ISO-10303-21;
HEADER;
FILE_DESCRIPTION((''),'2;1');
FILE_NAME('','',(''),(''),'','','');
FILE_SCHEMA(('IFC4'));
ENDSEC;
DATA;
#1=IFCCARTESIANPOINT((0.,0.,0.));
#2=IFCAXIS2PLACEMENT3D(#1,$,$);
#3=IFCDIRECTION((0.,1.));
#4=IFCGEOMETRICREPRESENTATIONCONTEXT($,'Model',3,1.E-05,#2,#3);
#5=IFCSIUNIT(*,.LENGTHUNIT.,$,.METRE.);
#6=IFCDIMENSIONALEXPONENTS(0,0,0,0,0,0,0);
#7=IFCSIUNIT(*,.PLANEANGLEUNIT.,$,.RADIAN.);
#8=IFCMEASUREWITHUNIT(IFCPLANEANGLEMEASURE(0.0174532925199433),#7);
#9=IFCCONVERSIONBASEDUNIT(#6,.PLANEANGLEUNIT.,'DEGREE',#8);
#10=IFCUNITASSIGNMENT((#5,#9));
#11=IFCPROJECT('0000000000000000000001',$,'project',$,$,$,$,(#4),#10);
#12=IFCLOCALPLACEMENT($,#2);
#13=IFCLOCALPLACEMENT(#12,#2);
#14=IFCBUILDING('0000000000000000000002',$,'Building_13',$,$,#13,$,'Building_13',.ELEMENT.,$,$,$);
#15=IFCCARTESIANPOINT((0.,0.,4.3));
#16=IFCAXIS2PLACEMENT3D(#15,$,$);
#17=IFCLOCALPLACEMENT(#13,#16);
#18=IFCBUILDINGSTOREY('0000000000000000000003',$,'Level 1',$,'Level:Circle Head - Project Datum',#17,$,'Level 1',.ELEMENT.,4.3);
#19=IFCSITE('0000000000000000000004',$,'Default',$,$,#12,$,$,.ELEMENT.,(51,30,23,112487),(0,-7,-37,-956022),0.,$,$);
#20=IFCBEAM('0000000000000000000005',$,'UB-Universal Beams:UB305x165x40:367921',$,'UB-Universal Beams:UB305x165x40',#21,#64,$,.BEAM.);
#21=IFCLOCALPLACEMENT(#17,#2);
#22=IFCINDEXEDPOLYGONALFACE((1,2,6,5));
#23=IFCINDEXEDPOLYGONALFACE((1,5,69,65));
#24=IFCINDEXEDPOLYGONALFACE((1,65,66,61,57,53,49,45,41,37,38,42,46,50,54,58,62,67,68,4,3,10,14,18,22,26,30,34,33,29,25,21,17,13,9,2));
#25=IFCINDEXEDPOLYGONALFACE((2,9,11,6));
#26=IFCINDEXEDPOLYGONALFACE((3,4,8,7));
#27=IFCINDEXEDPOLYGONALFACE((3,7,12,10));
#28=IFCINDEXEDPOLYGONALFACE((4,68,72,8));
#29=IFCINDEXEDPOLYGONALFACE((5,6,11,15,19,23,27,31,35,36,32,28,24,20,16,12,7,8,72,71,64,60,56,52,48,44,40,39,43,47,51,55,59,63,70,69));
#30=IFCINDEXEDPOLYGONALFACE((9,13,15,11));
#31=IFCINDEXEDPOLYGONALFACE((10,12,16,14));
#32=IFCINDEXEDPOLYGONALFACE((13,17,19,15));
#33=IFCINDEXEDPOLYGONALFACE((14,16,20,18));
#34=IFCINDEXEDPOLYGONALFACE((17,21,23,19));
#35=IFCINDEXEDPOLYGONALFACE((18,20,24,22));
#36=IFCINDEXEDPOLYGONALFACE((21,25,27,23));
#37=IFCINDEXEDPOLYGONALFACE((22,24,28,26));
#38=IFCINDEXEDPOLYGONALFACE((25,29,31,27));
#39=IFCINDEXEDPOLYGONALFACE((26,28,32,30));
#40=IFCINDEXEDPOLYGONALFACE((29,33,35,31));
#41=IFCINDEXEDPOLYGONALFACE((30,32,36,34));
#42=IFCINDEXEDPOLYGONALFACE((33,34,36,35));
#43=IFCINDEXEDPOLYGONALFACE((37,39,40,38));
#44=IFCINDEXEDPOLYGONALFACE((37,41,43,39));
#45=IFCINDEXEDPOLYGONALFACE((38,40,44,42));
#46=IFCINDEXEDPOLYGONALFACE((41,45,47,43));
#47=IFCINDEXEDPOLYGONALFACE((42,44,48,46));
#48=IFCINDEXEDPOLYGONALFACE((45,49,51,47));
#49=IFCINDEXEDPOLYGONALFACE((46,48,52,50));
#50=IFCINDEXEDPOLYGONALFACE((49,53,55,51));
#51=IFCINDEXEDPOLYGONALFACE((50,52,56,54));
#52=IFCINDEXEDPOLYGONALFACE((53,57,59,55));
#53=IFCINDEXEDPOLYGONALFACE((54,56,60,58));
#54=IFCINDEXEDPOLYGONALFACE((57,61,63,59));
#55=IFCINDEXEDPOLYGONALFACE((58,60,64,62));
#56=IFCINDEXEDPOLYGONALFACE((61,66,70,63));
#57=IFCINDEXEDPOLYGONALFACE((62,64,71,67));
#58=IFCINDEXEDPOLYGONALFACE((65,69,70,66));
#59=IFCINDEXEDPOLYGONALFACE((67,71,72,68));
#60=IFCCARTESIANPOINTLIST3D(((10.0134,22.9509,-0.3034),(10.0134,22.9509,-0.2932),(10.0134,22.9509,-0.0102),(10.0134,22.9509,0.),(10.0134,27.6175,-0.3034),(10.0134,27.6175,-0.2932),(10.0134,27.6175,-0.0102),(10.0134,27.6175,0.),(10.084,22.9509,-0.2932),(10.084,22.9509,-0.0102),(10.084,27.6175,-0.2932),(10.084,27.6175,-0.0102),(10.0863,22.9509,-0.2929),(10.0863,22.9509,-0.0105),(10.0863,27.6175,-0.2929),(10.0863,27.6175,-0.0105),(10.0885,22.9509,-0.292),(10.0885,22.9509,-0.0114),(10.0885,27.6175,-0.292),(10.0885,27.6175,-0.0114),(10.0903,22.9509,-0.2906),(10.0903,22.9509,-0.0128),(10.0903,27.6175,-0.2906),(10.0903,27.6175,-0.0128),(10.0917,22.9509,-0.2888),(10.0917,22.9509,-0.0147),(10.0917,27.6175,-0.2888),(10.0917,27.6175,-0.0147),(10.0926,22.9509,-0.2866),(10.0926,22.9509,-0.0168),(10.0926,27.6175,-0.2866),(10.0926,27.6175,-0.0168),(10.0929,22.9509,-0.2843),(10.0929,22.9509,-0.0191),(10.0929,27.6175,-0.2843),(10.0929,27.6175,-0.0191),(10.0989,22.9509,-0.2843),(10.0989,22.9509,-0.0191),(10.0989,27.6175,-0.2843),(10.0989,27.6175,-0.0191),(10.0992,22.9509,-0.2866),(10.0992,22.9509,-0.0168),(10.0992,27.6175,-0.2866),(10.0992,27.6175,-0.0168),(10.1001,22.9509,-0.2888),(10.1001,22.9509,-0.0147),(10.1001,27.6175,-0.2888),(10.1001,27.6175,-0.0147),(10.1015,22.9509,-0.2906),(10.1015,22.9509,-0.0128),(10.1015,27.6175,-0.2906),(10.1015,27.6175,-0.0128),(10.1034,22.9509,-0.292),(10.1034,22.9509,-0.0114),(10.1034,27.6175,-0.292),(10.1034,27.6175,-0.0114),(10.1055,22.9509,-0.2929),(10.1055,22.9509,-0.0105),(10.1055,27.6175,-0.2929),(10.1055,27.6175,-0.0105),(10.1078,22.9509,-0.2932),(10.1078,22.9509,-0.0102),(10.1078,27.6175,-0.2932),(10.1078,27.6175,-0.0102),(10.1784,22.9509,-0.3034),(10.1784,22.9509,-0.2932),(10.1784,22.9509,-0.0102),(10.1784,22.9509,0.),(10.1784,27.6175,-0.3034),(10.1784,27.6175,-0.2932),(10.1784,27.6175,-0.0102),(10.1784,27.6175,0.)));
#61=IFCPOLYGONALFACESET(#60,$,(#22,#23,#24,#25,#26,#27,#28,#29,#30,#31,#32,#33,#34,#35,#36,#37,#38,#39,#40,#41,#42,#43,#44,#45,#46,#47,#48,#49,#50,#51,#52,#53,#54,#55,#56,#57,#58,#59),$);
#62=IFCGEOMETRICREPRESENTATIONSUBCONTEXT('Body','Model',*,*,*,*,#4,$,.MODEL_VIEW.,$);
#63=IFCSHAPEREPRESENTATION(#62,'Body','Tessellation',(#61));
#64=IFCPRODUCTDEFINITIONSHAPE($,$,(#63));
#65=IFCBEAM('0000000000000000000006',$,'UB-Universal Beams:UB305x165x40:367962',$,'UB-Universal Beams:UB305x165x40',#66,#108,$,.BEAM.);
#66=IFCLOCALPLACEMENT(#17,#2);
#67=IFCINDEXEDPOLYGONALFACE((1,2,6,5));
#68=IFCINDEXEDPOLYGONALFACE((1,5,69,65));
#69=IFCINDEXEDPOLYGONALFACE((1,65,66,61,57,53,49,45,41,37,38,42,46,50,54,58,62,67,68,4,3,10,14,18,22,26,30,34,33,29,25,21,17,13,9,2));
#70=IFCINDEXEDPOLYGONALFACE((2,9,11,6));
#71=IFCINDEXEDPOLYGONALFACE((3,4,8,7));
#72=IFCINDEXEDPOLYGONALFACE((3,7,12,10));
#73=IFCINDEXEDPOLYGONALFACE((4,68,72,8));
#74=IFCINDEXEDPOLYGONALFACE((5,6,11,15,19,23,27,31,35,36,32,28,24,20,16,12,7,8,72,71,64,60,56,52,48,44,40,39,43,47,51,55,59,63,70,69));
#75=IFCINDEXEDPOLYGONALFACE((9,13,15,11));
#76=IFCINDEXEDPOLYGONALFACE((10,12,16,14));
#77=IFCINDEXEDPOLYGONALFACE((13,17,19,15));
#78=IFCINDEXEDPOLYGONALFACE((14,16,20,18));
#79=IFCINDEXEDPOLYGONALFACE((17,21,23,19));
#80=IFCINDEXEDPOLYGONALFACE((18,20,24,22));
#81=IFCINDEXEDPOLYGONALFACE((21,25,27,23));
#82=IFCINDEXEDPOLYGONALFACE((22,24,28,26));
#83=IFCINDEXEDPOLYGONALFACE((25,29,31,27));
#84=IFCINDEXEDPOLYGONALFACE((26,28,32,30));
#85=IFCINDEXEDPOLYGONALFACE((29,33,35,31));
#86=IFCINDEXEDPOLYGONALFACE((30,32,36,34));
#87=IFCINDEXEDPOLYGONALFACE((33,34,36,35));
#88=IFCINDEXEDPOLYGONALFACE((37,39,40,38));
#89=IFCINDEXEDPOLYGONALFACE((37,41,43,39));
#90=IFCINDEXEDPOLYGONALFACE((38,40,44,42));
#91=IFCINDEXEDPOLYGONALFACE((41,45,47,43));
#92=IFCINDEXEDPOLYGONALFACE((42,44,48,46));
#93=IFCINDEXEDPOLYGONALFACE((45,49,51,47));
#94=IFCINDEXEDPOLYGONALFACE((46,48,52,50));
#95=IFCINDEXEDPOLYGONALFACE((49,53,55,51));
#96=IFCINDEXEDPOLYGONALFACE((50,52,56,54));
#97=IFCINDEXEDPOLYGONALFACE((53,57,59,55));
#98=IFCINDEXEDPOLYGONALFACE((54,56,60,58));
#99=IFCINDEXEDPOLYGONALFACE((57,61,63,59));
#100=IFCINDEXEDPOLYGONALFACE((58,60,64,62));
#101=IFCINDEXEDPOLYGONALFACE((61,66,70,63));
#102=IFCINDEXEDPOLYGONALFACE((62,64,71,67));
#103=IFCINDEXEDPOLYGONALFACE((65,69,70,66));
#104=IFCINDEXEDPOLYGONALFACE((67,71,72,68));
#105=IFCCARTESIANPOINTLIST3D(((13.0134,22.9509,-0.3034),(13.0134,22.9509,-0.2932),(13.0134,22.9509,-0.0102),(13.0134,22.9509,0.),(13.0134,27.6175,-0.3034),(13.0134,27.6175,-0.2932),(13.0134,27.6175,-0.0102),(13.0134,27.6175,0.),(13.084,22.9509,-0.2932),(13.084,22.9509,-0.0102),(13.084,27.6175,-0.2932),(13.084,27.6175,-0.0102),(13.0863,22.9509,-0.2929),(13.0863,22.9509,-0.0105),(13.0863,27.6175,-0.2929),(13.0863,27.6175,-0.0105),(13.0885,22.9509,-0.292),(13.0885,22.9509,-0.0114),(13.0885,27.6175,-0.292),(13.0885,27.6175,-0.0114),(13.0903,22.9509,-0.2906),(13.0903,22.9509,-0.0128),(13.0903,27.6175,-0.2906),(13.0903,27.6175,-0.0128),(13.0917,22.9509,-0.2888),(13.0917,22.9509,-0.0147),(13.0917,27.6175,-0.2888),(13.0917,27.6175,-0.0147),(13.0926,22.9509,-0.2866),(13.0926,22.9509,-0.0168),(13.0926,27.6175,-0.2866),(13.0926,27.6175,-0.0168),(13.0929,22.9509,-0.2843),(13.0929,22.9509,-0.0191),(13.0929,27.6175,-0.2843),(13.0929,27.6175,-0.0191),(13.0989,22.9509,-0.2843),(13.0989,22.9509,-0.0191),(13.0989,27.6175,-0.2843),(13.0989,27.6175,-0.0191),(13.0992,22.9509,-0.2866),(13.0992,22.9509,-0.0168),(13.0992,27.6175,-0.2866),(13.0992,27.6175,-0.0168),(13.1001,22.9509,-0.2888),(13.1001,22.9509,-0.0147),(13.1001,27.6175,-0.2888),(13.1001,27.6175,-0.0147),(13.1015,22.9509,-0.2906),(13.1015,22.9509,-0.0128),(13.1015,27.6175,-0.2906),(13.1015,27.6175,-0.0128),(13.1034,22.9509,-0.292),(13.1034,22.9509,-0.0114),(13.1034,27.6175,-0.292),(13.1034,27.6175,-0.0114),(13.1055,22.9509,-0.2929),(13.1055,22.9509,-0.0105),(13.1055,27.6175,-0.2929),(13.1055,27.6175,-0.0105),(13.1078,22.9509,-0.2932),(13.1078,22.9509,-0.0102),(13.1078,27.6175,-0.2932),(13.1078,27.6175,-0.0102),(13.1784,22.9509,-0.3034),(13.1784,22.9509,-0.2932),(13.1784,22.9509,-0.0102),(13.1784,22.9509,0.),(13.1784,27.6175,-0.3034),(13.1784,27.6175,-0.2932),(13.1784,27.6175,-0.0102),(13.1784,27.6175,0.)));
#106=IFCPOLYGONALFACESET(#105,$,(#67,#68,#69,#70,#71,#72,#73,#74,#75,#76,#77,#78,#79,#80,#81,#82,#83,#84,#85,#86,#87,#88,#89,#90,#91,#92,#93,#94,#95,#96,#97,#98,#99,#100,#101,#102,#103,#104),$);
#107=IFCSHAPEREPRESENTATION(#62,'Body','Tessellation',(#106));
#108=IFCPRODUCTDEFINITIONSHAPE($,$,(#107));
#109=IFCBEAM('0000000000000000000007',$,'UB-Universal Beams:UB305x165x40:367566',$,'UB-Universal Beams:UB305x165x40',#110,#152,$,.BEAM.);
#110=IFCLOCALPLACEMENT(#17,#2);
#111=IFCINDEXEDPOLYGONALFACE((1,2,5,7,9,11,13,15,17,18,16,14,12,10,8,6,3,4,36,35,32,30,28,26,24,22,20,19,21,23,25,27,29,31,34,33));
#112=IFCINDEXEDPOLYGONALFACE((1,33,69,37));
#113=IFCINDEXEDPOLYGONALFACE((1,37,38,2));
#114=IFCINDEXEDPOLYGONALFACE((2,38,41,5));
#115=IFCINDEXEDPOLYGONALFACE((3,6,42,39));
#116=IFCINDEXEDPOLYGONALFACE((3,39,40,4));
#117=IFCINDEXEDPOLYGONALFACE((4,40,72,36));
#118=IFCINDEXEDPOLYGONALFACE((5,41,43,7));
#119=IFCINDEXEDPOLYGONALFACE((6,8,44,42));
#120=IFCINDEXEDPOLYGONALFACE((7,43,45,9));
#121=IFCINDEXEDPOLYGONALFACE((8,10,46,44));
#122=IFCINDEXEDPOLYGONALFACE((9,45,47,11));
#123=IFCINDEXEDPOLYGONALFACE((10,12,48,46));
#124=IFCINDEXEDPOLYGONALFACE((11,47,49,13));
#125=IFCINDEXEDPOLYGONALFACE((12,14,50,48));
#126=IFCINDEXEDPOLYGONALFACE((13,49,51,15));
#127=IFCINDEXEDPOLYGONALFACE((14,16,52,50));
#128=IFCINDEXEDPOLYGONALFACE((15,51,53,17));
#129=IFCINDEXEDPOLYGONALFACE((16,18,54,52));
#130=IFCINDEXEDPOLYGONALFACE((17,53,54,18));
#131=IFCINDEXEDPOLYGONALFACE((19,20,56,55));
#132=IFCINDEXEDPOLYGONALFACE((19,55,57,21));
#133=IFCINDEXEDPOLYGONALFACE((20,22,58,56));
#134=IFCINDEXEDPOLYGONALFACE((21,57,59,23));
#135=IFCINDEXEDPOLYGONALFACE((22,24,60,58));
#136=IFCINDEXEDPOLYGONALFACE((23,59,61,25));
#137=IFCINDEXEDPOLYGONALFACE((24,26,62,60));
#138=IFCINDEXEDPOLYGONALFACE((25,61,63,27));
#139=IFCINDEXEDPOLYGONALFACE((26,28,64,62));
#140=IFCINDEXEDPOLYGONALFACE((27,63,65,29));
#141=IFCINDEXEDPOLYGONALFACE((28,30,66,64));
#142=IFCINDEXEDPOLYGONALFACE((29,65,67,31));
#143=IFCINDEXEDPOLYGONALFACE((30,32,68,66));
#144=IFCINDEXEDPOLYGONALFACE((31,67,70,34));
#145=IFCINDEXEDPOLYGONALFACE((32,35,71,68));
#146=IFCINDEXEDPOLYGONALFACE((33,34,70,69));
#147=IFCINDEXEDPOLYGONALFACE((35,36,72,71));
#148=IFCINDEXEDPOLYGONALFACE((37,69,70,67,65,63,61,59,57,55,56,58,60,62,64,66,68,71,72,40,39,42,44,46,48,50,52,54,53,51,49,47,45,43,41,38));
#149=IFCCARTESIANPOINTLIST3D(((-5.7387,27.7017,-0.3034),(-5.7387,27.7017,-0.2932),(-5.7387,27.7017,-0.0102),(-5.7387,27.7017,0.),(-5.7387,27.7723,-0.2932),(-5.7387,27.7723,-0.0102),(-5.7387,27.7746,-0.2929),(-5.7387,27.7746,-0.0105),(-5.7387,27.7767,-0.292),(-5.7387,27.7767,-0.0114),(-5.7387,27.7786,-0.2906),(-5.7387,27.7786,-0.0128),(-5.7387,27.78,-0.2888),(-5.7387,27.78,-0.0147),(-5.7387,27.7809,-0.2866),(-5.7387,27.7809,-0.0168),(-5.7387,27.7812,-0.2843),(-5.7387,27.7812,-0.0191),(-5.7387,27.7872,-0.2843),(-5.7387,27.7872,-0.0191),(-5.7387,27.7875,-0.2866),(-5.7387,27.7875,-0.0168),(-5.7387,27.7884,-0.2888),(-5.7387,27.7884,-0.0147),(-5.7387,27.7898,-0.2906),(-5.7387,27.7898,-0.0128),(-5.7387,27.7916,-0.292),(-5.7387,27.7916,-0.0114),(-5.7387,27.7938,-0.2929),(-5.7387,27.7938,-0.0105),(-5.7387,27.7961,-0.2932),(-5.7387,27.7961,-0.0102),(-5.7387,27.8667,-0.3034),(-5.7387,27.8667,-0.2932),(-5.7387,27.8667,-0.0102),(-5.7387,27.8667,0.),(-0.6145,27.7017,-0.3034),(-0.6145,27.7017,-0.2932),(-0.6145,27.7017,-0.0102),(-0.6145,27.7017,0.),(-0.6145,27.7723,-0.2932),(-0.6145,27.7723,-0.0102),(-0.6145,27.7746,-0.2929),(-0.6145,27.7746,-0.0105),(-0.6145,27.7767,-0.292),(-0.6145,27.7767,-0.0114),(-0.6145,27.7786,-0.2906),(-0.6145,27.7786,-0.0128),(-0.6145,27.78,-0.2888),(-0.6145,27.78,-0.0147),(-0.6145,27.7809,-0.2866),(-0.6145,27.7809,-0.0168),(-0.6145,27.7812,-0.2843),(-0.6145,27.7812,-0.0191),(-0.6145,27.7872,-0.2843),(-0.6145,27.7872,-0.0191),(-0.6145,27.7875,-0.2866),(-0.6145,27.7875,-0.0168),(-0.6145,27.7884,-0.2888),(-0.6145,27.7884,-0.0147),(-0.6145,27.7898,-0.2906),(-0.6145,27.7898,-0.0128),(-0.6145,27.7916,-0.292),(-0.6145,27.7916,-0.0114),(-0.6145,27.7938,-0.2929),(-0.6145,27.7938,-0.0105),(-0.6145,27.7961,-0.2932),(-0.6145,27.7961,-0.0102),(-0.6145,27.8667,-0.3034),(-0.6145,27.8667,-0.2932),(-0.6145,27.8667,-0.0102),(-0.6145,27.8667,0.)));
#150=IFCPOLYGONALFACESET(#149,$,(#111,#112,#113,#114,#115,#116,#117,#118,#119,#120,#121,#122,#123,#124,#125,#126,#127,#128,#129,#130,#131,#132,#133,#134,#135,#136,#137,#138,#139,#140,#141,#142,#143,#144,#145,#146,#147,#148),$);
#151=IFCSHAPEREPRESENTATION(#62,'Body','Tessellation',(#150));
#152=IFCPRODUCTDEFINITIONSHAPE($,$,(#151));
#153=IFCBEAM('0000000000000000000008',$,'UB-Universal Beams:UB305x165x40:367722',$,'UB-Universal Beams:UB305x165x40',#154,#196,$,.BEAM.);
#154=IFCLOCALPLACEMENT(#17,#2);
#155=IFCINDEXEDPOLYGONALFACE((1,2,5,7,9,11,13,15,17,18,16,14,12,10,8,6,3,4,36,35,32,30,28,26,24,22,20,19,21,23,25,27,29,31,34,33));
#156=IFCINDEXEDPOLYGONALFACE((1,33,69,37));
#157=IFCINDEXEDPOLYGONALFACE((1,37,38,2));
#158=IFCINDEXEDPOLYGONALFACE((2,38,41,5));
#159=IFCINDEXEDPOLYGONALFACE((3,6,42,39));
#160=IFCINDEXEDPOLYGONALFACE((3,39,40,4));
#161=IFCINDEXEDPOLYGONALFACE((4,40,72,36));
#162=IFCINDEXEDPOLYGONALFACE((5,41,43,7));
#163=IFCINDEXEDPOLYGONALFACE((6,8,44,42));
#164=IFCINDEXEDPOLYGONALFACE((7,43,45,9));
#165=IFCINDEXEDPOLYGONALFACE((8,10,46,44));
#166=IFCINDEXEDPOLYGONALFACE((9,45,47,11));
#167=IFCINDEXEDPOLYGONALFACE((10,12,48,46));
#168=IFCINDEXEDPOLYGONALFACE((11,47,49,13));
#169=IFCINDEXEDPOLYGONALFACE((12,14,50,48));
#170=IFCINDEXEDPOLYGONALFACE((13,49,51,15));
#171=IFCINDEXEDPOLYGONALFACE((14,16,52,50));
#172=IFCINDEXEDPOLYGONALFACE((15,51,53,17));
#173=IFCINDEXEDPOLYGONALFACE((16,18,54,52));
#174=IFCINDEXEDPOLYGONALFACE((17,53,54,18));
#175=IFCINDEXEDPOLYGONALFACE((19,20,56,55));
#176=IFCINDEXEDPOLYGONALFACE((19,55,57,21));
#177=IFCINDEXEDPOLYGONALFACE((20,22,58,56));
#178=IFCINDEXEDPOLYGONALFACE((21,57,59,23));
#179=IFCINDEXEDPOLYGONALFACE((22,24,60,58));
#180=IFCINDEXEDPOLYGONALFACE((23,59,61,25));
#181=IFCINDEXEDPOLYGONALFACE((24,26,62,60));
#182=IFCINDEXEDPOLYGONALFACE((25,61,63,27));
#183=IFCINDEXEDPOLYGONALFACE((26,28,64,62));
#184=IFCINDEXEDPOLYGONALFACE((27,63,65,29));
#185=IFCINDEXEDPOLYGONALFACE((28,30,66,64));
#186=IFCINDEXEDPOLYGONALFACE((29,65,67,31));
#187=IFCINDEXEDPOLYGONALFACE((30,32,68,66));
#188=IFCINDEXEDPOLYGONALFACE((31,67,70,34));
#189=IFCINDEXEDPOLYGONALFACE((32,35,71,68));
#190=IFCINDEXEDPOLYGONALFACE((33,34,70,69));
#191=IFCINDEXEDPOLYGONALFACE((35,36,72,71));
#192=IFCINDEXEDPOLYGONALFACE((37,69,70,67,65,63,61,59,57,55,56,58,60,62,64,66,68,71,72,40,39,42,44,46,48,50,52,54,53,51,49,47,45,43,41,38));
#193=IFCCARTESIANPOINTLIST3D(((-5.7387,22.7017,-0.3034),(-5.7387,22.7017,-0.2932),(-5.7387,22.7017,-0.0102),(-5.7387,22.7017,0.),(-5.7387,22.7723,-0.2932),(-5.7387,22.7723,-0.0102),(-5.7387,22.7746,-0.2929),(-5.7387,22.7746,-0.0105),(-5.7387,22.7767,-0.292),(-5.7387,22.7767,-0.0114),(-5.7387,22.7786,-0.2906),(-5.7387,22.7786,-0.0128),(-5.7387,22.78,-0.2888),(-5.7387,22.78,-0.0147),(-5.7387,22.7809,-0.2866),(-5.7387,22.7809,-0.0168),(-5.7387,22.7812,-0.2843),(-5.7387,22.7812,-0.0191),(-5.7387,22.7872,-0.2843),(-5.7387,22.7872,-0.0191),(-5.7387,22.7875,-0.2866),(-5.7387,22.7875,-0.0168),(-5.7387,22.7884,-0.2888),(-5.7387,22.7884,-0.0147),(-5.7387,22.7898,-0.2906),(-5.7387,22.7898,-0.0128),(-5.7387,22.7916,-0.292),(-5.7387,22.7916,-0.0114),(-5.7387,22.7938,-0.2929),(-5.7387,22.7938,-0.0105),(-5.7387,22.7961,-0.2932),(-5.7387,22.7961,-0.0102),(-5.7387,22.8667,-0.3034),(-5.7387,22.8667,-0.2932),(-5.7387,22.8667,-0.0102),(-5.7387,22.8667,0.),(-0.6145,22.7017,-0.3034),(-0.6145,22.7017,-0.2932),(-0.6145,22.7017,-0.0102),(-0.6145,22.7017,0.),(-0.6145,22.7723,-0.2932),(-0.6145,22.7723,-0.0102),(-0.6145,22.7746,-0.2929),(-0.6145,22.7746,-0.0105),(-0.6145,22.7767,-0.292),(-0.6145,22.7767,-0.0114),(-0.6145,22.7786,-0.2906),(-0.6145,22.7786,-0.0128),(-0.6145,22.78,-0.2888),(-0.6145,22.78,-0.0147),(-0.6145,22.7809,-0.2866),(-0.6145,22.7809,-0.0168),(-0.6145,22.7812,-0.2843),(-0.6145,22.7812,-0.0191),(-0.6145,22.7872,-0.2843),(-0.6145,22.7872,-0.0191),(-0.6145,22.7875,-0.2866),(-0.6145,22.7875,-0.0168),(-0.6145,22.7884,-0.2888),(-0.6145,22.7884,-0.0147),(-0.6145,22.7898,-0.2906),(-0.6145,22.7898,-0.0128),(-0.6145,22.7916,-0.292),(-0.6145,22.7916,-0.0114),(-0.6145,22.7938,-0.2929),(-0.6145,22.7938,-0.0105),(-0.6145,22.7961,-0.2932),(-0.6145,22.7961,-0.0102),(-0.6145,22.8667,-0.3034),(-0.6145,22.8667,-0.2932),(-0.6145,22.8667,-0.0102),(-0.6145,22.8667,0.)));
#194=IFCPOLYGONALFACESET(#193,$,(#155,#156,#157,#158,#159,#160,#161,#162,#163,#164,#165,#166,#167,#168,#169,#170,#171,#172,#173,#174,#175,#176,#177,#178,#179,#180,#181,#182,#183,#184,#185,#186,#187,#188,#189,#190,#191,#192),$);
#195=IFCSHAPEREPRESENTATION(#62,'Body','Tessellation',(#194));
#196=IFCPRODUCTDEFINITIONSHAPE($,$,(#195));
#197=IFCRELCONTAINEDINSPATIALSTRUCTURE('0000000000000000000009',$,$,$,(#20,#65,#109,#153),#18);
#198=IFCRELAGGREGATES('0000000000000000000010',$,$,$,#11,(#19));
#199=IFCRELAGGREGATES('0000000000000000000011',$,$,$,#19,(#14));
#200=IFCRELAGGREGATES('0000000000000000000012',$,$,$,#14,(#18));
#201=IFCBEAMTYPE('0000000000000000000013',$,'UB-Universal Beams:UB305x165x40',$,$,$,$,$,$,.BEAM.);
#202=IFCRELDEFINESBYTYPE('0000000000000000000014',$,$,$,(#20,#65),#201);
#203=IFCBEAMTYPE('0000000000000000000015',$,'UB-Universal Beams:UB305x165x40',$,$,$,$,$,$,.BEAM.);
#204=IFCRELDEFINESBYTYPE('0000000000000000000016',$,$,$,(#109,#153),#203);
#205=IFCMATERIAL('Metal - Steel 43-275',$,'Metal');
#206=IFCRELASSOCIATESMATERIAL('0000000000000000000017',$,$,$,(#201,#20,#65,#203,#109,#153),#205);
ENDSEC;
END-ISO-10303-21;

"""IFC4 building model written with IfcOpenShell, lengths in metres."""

from ifc_helpers import new_model, entity, si_unit, converted_unit, direction, frame, origin, place, context, subcontext, project, spatial, line, arc, indexed_curve, outline, extrude, source, transform, mapped, material, type_object, type_shapes, element, save


model = new_model("IFC4")

# Units and contexts
model_context = context("Model", 3, precision=1e-05, world=origin(), true_north=direction((0.0, 1.0)))
body_context = subcontext(model_context, "Body", "Model", "MODEL_VIEW")
ifc_project = project(units=[si_unit("LENGTHUNIT", "METRE"), converted_unit("PLANEANGLEUNIT", "DEGREE", entity("IfcPlaneAngleMeasure", 0.0174532925199433), si_unit("PLANEANGLEUNIT", "RADIAN"), dimensions=[0, 0, 0, 0, 0, 0, 0])], contexts=[model_context])

# Site, building, storey
site_placement = place(None, origin())
site = spatial("IfcSite", under=ifc_project, at=site_placement, Name="Default", CompositionType="ELEMENT", RefLatitude=(51, 30, 23, 112487), RefLongitude=(0, -7, -37, -956022), RefElevation=0.0)
building_placement = place(site_placement, origin())
building = spatial("IfcBuilding", under=site, at=building_placement, Name="Building_13", LongName="Building_13", CompositionType="ELEMENT")
storey_placement = place(building_placement, frame((0.0, 0.0, 4.3)))
storey = spatial("IfcBuildingStorey", under=building, at=storey_placement, Name="Level 1", ObjectType="Level:Circle Head - Project Datum", LongName="Level 1", CompositionType="ELEMENT", Elevation=4.3)

# Beams
ifc_material_1 = material(Name="Metal - Steel 43-275", Category="Metal")
beam_type_1 = type_object("IfcBeamType", Name="UB-Universal Beams:UB305x165x40", PredefinedType="BEAM", material=ifc_material_1)
shared_shape_1 = source(origin(), body_context, "Body", "SweptSolid", [
    extrude(outline(indexed_curve([(-0.0825, -0.1415), (-0.0825, -0.1517), (0.0825, -0.1517), (0.0825, -0.1415), (0.0119, -0.1415), (0.0056, -0.1389), (0.003, -0.1326), (0.003, 0.1326), (0.0056, 0.1389), (0.0119, 0.1415), (0.0825, 0.1415), (0.0825, 0.1517), (-0.0825, 0.1517), (-0.0825, 0.1415), (-0.0119, 0.1415), (-0.0056, 0.1389), (-0.003, 0.1326), (-0.003, -0.1326), (-0.0056, -0.1389), (-0.0119, -0.1415)], segments=[line(1, 2, 3, 4, 5), arc(5, 6, 7), line(7, 8), arc(8, 9, 10), line(10, 11, 12, 13, 14, 15), arc(15, 16, 17), line(17, 18), arc(18, 19, 20), line(20, 1)], self_intersect=False)), frame((-2.3333, 0.0, 0.0), z_axis=(-1.0, 0.0, 0.0), x_axis=(0.0, -1.0, 0.0)), (0.0, 0.0, -1.0), 4.6666),
])
type_shapes(beam_type_1, [shared_shape_1])
for number, where, z_axis, x_axis, name in (
    (1, (10.0959, 25.2842, -0.1517), (0.0, 0.0, 1.0), (0.0, -1.0, 0.0), "UB-Universal Beams:UB305x165x40:367921"),
    (2, (13.0959, 25.2842, -0.1517), (0.0, 0.0, 1.0), (0.0, -1.0, 0.0), "UB-Universal Beams:UB305x165x40:367962"),
):
    element("IfcBeam", number, at=place(storey_placement, frame(where, z_axis=z_axis, x_axis=x_axis)), inside=storey, type_object=beam_type_1, material=ifc_material_1, Name=name, ObjectType="UB-Universal Beams:UB305x165x40", PredefinedType="BEAM", context=body_context, shape_type="MappedRepresentation", body=[
        mapped(shared_shape_1, transform((0.0, 0.0, 0.0), scale=1.0)),
    ])
beam_type_2 = type_object("IfcBeamType", Name="UB-Universal Beams:UB305x165x40", PredefinedType="BEAM", material=ifc_material_1)
shared_shape_2 = source(origin(), body_context, "Body", "SweptSolid", [
    extrude(outline(indexed_curve([(-0.0825, -0.1415), (-0.0825, -0.1517), (0.0825, -0.1517), (0.0825, -0.1415), (0.0119, -0.1415), (0.0056, -0.1389), (0.003, -0.1326), (0.003, 0.1326), (0.0056, 0.1389), (0.0119, 0.1415), (0.0825, 0.1415), (0.0825, 0.1517), (-0.0825, 0.1517), (-0.0825, 0.1415), (-0.0119, 0.1415), (-0.0056, 0.1389), (-0.003, 0.1326), (-0.003, -0.1326), (-0.0056, -0.1389), (-0.0119, -0.1415)], segments=[line(1, 2, 3, 4, 5), arc(5, 6, 7), line(7, 8), arc(8, 9, 10), line(10, 11, 12, 13, 14, 15), arc(15, 16, 17), line(17, 18), arc(18, 19, 20), line(20, 1)], self_intersect=False)), frame((-2.5621, 0.0, 0.0), z_axis=(-1.0, 0.0, 0.0), x_axis=(0.0, -1.0, 0.0)), (0.0, 0.0, -1.0), 5.1242),
])
type_shapes(beam_type_2, [shared_shape_2])
for number, where, name in (
    (3, (-3.1766, 27.7842, -0.1517), "UB-Universal Beams:UB305x165x40:367566"),
    (4, (-3.1766, 22.7842, -0.1517), "UB-Universal Beams:UB305x165x40:367722"),
):
    element("IfcBeam", number, at=place(storey_placement, frame(where)), inside=storey, type_object=beam_type_2, material=ifc_material_1, Name=name, ObjectType="UB-Universal Beams:UB305x165x40", PredefinedType="BEAM", context=body_context, shape_type="MappedRepresentation", body=[
        mapped(shared_shape_2, transform((0.0, 0.0, 0.0), scale=1.0)),
    ])

save(model, "model.ifc")
